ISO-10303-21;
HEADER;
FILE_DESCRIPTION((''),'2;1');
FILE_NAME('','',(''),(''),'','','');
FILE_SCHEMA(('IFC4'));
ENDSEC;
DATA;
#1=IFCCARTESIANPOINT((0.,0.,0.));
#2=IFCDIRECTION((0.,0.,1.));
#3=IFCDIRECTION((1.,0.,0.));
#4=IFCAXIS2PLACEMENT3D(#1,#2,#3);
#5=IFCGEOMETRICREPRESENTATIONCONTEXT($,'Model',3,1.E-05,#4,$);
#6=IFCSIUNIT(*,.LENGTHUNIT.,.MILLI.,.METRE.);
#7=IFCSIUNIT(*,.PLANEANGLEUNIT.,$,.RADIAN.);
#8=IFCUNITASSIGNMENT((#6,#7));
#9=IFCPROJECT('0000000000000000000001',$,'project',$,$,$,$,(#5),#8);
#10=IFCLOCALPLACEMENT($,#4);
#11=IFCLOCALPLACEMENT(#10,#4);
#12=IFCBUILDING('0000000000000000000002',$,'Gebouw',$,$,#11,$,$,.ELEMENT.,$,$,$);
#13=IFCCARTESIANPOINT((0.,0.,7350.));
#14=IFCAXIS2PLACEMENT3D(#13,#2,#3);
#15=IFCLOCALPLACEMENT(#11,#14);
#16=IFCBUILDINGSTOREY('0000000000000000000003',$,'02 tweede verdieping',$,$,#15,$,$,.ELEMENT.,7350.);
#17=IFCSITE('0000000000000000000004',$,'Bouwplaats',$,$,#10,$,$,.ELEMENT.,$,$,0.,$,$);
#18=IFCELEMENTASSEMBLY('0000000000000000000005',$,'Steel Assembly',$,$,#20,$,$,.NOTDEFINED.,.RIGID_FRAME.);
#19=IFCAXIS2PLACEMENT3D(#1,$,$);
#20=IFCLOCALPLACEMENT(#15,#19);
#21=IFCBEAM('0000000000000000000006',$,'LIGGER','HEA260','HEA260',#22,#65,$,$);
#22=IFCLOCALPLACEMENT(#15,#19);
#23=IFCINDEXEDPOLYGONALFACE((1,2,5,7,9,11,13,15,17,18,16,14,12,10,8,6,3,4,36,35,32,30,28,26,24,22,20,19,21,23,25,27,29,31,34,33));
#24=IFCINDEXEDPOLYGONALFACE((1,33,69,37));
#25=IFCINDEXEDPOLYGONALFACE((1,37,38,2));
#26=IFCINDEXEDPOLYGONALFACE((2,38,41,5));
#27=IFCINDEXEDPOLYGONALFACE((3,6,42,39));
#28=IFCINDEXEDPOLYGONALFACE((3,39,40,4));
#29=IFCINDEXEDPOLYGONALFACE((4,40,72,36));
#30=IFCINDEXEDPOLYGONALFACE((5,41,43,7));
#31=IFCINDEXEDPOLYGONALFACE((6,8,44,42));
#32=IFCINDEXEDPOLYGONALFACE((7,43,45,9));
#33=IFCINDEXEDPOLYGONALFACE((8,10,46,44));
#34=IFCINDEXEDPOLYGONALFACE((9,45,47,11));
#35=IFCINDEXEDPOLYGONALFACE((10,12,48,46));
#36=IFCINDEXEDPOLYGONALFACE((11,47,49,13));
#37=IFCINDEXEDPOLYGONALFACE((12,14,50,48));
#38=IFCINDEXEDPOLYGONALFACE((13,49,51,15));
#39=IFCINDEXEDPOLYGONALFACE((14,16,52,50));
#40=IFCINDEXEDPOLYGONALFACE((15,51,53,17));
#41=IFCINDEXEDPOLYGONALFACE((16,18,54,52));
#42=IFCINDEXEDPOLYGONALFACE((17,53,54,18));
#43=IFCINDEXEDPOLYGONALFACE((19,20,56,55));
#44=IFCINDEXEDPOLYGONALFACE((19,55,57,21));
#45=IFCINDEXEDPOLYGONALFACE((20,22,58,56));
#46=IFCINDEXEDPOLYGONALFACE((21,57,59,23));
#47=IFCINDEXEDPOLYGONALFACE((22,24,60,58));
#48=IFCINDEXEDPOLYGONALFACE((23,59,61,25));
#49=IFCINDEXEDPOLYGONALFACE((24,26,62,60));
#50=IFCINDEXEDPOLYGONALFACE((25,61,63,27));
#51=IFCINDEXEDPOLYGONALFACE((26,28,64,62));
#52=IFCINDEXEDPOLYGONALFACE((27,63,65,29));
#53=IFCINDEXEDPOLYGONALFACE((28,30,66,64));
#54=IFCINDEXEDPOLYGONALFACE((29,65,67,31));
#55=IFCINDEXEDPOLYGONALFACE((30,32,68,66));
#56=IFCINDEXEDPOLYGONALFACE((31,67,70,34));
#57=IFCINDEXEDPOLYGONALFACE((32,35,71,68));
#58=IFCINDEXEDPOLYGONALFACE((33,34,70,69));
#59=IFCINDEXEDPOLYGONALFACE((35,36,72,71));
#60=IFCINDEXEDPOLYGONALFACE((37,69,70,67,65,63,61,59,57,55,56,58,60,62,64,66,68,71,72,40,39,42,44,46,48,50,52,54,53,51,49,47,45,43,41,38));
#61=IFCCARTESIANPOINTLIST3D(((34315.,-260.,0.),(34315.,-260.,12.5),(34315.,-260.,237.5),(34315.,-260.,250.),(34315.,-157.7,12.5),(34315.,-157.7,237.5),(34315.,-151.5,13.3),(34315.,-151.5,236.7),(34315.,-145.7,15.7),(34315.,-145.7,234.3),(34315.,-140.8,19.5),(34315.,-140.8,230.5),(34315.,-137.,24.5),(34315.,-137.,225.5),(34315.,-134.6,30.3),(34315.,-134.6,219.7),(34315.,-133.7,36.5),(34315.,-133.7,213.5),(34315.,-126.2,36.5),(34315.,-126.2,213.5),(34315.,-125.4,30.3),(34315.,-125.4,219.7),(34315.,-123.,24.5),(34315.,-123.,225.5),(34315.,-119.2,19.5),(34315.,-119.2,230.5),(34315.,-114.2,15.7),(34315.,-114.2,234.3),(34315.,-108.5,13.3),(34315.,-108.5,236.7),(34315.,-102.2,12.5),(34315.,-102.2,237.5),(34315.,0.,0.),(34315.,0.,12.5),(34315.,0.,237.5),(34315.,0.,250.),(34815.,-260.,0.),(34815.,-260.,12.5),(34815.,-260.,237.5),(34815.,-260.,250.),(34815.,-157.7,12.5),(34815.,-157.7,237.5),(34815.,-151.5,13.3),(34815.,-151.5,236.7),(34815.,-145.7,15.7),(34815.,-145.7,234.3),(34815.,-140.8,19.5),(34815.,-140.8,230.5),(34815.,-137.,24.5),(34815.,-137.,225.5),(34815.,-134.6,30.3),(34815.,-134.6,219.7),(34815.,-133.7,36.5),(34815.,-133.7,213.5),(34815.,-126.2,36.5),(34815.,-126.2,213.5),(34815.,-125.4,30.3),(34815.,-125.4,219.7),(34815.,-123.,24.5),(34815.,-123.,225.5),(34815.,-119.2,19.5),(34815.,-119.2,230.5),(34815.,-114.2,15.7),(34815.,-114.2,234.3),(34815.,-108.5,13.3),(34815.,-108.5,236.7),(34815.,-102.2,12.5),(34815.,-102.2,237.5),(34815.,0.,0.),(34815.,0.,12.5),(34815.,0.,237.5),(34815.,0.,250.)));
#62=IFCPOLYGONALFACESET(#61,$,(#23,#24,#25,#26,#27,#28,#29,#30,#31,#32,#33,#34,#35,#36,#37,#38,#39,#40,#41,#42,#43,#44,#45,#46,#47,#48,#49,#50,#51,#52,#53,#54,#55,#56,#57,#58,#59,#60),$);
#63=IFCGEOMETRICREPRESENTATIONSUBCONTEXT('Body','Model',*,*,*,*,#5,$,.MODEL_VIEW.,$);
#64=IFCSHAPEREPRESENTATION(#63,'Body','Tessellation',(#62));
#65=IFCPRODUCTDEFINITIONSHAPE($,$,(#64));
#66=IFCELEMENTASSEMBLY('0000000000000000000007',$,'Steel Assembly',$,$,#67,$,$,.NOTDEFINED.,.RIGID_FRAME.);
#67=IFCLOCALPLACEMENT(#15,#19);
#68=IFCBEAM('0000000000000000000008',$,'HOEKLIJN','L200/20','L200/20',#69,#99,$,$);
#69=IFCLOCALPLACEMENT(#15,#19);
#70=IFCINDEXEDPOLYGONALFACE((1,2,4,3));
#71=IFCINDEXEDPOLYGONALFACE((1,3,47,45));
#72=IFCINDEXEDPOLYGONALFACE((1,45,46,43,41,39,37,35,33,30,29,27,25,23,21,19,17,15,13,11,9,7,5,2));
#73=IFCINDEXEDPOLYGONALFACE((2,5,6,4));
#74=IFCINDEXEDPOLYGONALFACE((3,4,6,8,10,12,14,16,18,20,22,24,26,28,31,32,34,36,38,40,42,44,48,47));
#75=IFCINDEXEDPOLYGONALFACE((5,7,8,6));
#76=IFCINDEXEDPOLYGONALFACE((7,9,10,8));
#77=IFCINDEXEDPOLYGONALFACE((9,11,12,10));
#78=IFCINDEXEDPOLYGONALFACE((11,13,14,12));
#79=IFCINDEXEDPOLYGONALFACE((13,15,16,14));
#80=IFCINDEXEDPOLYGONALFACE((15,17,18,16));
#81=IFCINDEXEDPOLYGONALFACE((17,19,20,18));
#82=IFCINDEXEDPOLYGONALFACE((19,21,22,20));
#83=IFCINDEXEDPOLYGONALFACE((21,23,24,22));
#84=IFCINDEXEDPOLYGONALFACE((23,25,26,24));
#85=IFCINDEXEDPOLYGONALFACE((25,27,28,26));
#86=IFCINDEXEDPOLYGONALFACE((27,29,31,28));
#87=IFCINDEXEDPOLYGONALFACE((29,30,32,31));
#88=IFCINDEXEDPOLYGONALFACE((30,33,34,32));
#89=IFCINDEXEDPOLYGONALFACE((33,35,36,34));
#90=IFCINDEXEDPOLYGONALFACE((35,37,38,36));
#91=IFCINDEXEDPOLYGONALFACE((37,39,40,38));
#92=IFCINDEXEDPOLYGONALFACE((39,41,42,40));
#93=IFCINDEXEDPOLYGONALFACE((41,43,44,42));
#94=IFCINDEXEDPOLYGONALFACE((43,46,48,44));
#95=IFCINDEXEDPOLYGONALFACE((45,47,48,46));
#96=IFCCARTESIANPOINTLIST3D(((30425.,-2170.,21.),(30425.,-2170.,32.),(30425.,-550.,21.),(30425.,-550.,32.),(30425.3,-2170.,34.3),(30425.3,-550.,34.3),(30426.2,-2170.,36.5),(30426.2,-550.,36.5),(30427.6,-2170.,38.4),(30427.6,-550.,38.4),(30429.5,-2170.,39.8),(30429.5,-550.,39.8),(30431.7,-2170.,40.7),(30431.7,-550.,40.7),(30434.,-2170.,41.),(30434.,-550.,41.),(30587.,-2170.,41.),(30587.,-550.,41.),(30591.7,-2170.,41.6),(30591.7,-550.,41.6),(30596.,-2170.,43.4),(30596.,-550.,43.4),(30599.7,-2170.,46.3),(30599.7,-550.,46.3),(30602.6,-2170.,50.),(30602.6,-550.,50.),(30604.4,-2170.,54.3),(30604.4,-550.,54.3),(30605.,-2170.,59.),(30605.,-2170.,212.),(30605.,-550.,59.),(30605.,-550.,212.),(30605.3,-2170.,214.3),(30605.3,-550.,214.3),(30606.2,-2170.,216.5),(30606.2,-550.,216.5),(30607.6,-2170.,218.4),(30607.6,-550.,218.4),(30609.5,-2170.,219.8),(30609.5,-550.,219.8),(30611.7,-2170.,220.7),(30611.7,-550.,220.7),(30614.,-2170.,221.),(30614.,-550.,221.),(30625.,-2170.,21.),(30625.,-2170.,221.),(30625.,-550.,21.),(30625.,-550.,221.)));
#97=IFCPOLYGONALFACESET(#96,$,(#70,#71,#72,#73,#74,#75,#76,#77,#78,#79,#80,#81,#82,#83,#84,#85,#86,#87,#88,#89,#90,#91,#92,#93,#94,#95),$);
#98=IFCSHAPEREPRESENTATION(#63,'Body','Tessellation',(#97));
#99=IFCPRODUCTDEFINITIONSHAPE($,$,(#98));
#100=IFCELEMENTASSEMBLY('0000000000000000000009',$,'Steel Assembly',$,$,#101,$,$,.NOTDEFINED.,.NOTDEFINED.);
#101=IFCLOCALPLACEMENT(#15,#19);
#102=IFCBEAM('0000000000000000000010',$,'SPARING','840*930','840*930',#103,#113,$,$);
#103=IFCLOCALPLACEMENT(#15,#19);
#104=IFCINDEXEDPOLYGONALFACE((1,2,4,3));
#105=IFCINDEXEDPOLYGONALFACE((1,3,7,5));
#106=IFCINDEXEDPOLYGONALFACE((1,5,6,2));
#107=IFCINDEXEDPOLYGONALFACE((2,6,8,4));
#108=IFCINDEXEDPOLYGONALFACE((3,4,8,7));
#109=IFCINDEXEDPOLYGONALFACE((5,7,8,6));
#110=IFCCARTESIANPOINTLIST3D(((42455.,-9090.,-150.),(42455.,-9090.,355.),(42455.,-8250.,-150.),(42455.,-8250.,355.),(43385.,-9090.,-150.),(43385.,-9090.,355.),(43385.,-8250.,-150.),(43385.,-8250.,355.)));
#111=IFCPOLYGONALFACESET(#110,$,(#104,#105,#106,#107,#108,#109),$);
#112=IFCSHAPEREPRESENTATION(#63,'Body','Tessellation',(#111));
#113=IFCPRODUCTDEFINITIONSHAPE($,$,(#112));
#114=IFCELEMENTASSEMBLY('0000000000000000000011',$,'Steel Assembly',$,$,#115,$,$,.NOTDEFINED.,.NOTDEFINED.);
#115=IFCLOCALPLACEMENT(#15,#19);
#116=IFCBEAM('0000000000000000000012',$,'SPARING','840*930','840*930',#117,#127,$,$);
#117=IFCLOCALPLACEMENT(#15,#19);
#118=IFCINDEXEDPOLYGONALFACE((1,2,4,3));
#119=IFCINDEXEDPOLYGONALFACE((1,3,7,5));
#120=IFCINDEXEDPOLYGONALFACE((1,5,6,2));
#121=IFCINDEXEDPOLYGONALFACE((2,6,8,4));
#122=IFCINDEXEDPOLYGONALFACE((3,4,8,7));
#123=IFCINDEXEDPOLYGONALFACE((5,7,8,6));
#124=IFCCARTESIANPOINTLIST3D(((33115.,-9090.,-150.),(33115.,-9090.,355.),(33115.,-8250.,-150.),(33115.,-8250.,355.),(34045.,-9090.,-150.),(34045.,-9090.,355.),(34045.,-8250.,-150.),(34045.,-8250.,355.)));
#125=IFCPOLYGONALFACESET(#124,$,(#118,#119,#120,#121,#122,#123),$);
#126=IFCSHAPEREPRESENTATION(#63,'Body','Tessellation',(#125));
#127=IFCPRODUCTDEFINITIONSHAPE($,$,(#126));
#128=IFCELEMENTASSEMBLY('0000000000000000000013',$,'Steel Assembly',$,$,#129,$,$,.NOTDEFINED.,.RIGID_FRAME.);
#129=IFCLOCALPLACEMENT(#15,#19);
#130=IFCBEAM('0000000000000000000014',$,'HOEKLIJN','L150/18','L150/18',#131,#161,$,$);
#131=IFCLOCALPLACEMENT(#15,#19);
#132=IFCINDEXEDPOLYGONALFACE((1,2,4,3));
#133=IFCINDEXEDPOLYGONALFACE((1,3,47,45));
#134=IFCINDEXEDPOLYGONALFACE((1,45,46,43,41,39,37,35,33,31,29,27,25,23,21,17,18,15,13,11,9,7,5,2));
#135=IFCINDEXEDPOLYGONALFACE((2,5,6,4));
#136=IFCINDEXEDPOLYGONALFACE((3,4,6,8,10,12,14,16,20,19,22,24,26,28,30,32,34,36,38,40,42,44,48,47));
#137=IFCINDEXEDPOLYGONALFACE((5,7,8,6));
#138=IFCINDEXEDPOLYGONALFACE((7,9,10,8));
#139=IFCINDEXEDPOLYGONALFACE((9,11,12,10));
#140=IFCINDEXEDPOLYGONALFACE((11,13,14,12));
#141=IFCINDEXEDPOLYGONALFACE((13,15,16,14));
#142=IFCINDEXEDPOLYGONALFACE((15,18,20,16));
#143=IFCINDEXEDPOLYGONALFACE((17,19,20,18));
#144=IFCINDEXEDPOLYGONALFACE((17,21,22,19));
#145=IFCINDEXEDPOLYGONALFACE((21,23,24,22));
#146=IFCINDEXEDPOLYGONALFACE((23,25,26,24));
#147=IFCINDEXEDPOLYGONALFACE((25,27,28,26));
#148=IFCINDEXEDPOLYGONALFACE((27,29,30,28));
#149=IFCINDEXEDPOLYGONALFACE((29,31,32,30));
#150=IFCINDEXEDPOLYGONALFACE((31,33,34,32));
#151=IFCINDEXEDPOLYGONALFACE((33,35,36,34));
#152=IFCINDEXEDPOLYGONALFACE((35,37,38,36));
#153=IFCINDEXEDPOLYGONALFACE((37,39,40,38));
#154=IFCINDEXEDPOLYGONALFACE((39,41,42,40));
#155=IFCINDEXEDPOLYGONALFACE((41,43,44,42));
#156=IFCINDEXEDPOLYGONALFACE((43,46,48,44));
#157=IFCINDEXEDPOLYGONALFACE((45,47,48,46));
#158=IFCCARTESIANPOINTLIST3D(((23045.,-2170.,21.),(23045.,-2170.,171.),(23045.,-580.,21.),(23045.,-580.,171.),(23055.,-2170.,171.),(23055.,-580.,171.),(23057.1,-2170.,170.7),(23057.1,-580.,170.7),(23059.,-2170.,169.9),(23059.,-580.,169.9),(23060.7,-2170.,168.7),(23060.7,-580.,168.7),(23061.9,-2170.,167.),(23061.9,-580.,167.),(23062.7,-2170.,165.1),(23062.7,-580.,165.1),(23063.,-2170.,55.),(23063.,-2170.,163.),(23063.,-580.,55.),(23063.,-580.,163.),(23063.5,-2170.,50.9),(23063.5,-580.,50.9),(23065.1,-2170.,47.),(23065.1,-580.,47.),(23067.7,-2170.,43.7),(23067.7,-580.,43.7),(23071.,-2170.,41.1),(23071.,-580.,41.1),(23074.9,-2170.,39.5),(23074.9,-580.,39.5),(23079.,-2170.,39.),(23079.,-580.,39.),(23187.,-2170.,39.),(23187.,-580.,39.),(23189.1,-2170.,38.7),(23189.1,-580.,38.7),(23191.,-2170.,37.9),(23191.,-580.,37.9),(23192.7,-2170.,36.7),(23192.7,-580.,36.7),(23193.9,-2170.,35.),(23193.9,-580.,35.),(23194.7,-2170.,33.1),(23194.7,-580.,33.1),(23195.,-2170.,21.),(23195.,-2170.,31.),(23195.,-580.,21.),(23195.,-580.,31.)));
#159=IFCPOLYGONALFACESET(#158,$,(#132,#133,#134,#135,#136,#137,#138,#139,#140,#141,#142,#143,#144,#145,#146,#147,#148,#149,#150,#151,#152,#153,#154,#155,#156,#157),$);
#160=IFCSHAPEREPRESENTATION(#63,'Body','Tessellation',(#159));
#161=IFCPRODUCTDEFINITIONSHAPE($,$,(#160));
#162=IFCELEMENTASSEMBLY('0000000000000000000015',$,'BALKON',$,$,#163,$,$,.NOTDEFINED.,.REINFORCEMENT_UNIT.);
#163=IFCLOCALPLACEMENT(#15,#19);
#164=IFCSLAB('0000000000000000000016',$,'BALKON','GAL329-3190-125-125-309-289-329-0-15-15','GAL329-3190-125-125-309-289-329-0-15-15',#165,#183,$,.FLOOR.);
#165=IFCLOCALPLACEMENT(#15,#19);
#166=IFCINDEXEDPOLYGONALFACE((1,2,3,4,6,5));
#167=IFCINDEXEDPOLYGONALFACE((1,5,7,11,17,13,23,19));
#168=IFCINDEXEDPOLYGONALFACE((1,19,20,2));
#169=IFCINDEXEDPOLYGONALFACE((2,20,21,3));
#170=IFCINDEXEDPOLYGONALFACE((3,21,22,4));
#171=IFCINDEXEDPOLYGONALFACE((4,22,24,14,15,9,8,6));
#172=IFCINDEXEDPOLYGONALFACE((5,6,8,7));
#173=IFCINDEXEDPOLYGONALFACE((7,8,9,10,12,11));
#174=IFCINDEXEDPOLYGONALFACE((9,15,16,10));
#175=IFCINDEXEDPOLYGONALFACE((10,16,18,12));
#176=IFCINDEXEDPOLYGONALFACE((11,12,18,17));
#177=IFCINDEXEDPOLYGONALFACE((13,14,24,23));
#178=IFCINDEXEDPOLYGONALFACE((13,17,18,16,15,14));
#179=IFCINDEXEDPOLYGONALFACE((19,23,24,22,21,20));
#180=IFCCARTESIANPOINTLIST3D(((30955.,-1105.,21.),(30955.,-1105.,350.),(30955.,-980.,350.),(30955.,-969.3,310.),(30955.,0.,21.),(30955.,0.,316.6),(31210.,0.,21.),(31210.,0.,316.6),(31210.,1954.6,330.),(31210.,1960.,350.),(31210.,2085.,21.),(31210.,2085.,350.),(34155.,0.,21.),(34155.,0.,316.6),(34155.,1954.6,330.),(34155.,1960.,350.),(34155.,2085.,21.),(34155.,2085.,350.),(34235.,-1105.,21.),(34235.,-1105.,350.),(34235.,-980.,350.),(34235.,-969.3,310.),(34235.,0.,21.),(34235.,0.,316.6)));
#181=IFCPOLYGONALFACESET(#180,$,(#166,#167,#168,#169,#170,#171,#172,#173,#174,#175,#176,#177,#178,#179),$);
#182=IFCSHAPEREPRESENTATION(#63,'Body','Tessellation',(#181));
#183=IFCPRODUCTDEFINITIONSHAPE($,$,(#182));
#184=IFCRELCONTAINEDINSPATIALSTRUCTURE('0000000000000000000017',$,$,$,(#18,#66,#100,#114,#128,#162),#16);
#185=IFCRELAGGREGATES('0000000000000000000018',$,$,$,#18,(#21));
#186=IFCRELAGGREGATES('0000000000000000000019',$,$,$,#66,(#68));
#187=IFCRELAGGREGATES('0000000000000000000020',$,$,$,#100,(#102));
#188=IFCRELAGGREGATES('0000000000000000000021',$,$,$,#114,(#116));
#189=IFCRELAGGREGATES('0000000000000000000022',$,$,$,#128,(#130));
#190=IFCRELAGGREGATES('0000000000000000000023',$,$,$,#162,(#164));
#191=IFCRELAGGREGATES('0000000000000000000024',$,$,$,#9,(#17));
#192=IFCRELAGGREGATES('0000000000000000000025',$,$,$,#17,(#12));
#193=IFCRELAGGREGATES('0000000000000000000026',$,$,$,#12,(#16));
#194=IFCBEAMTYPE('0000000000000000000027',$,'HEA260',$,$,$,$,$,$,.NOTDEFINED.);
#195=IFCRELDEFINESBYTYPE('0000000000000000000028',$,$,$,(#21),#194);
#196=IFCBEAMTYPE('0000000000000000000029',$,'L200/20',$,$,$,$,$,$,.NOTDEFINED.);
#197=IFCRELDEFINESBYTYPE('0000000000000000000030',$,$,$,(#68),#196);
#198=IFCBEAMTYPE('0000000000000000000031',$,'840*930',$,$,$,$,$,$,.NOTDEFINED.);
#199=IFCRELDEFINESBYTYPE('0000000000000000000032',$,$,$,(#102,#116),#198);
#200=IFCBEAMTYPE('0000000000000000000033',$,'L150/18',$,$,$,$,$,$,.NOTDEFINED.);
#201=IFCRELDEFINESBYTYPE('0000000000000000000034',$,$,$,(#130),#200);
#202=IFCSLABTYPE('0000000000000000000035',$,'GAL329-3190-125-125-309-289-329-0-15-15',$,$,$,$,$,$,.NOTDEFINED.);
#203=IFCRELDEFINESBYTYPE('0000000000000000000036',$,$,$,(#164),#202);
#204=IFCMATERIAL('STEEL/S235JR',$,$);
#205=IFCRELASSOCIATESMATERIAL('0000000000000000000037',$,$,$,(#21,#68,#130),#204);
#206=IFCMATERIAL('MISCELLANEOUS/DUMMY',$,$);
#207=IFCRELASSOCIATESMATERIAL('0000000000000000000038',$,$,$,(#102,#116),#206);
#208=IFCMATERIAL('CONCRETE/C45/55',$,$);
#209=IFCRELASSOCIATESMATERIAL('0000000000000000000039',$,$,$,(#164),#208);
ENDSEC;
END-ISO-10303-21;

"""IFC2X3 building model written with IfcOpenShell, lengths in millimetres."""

from ifc_helpers import new_model, si_unit, frame, origin_with_axes, origin_2d_with_axis, place, context, subcontext, project, spatial, polyline, rectangle, i_section, l_section, outline, extrude, boolean, material, type_object, element, aggregate, save


model = new_model("IFC2X3")

# Units and contexts
model_context = context("Model", 3, precision=1e-05, world=origin_with_axes())
body_context = subcontext(model_context, "Body", "Model", "MODEL_VIEW")
ifc_project = project(units=[si_unit("LENGTHUNIT", "METRE", prefix="MILLI"), si_unit("PLANEANGLEUNIT", "RADIAN")], contexts=[model_context])

# Site, building, storey
site_placement = place(None, origin_with_axes())
site = spatial("IfcSite", under=ifc_project, at=site_placement, Name="Bouwplaats", CompositionType="ELEMENT", RefElevation=0.0)
building_placement = place(site_placement, origin_with_axes())
building = spatial("IfcBuilding", under=site, at=building_placement, Name="Gebouw", CompositionType="ELEMENT")
storey_placement = place(building_placement, frame((0.0, 0.0, 7350.0), z_axis=(0.0, 0.0, 1.0), x_axis=(1.0, 0.0, 0.0)))
storey = spatial("IfcBuildingStorey", under=building, at=storey_placement, Name="02 tweede verdieping", CompositionType="ELEMENT", Elevation=7350.0)

# Shared definitions
ifc_material_1 = material(Name="STEEL/S235JR")

# Element assemblies, beams
ifc_material_2 = material(Name="MISCELLANEOUS/DUMMY")
beam_type_1 = type_object("IfcBeamType", Name="HEA260", PredefinedType="NOTDEFINED")
assembly_1_placement = place(storey_placement, origin_with_axes())
assembly_1 = element("IfcElementAssembly", 1, at=assembly_1_placement, inside=storey, Name="Steel Assembly", AssemblyPlace="NOTDEFINED", PredefinedType="RIGID_FRAME")
beam_1_placement = place(assembly_1_placement, frame((34315.0, -130.0, 125.0), z_axis=(0.0, 0.0, 1.0), x_axis=(1.0, 0.0, 0.0)))
beam_1 = element("IfcBeam", 2, at=beam_1_placement, type_object=beam_type_1, material=ifc_material_1, Name="LIGGER", Description="HEA260", ObjectType="HEA260", context=body_context, shape_type="SweptSolid", body=[
    extrude(i_section(OverallWidth=260.0, OverallDepth=250.0, WebThickness=7.5, FlangeThickness=12.5, FilletRadius=24.0, at=origin_2d_with_axis()), frame((500.0, 0.0, 0.0), z_axis=(-1.0, 0.0, 0.0), x_axis=(0.0, -1.0, 0.0)), (0.0, 0.0, 1.0), 500.0),
])
aggregate(assembly_1, [beam_1])
assembly_2_placement = place(storey_placement, origin_with_axes())
assembly_2 = element("IfcElementAssembly", 3, at=assembly_2_placement, inside=storey, Name="Steel Assembly", AssemblyPlace="NOTDEFINED", PredefinedType="RIGID_FRAME")
beam_type_2 = type_object("IfcBeamType", Name="L200/20", PredefinedType="NOTDEFINED")
beam_2_placement = place(assembly_2_placement, frame((30525.0, -2170.0, 121.0), z_axis=(-1.0, 0.0, 0.0), x_axis=(0.0, 1.0, 0.0)))
beam_2 = element("IfcBeam", 4, at=beam_2_placement, type_object=beam_type_2, material=ifc_material_1, Name="HOEKLIJN", Description="L200/20", ObjectType="L200/20", context=body_context, shape_type="SweptSolid", body=[
    extrude(l_section(Depth=200.0, Width=200.0, Thickness=20.0, FilletRadius=18.0, EdgeRadius=9.0, at=origin_2d_with_axis()), frame((1620.0, 0.0, 0.0), z_axis=(-1.0, 0.0, 0.0), x_axis=(0.0, -1.0, 0.0)), (0.0, 0.0, 1.0), 1620.0),
])
aggregate(assembly_2, [beam_2])
assembly_3_placement = place(storey_placement, origin_with_axes())
assembly_3 = element("IfcElementAssembly", 5, at=assembly_3_placement, inside=storey, Name="Steel Assembly", AssemblyPlace="NOTDEFINED", PredefinedType="NOTDEFINED")
beam_type_3 = type_object("IfcBeamType", Name="840*930", PredefinedType="NOTDEFINED")
beam_3_placement = place(assembly_3_placement, frame((42920.0, -8670.0, 355.0), z_axis=(1.0, -0.000004, 0.0), x_axis=(0.0, 0.0, -1.0)))
beam_3 = element("IfcBeam", 6, at=beam_3_placement, type_object=beam_type_3, material=ifc_material_2, Name="SPARING", Description="840*930", ObjectType="840*930", context=body_context, shape_type="SweptSolid", body=[
    extrude(rectangle(XDim=840.0, YDim=930.0, at=origin_2d_with_axis()), frame((505.0, 0.0, 0.0), z_axis=(-1.0, 0.0, 0.0), x_axis=(0.0, -1.0, 0.0)), (0.0, 0.0, 1.0), 505.0),
])
aggregate(assembly_3, [beam_3])
assembly_4_placement = place(storey_placement, origin_with_axes())
assembly_4 = element("IfcElementAssembly", 7, at=assembly_4_placement, inside=storey, Name="Steel Assembly", AssemblyPlace="NOTDEFINED", PredefinedType="NOTDEFINED")
beam_4_placement = place(assembly_4_placement, frame((33580.0, -8670.0, 355.0), z_axis=(1.0, -0.000004, 0.0), x_axis=(0.0, 0.0, -1.0)))
beam_4 = element("IfcBeam", 8, at=beam_4_placement, type_object=beam_type_3, material=ifc_material_2, Name="SPARING", Description="840*930", ObjectType="840*930", context=body_context, shape_type="SweptSolid", body=[
    extrude(rectangle(XDim=840.0, YDim=930.0, at=origin_2d_with_axis()), frame((505.0, 0.0, 0.0), z_axis=(-1.0, 0.0, 0.0), x_axis=(0.0, -1.0, 0.0)), (0.0, 0.0, 1.0), 505.0),
])
aggregate(assembly_4, [beam_4])
assembly_5_placement = place(storey_placement, origin_with_axes())
assembly_5 = element("IfcElementAssembly", 9, at=assembly_5_placement, inside=storey, Name="Steel Assembly", AssemblyPlace="NOTDEFINED", PredefinedType="RIGID_FRAME")
beam_type_4 = type_object("IfcBeamType", Name="L150/18", PredefinedType="NOTDEFINED")
beam_5_placement = place(assembly_5_placement, frame((23120.0, -2170.0, 96.0), z_axis=(0.0, 0.0, 1.0), x_axis=(0.0, 1.0, 0.0)))
beam_5 = element("IfcBeam", 10, at=beam_5_placement, type_object=beam_type_4, material=ifc_material_1, Name="HOEKLIJN", Description="L150/18", ObjectType="L150/18", context=body_context, shape_type="SweptSolid", body=[
    extrude(l_section(Depth=150.0, Width=150.0, Thickness=18.0, FilletRadius=16.0, EdgeRadius=8.0, at=origin_2d_with_axis()), frame((1590.0, 0.0, 0.0), z_axis=(-1.0, 0.0, 0.0), x_axis=(0.0, -1.0, 0.0)), (0.0, 0.0, 1.0), 1590.0),
])
aggregate(assembly_5, [beam_5])

# Element assembly, slab
assembly_6_placement = place(storey_placement, origin_with_axes())
assembly_6 = element("IfcElementAssembly", 11, at=assembly_6_placement, inside=storey, Name="BALKON", AssemblyPlace="NOTDEFINED", PredefinedType="REINFORCEMENT_UNIT")
ifc_material_3 = material(Name="CONCRETE/C45/55")
slab_type_1 = type_object("IfcSlabType", Name="GAL329-3190-125-125-309-289-329-0-15-15", PredefinedType="NOTDEFINED")
slab_1_placement = place(assembly_6_placement, frame((30955.0, 490.0, 185.5), z_axis=(0.0, 0.0, 1.0), x_axis=(1.0, 0.0, 0.0)))
slab_1 = element("IfcSlab", 12, at=slab_1_placement, type_object=slab_type_1, material=ifc_material_3, Name="BALKON", Description="GAL329-3190-125-125-309-289-329-0-15-15", ObjectType="GAL329-3190-125-125-309-289-329-0-15-15", PredefinedType="FLOOR", context=body_context, shape_type="CSG", body=[
    boolean("DIFFERENCE", boolean("DIFFERENCE", extrude(outline(polyline([(1595.0, -164.5), (-1595.0, -164.5), (-1595.0, 164.5), (-1470.0, 164.5), (-1464.6, 144.5), (1459.3, 124.5), (1470.0, 164.5), (1595.0, 164.5), (1595.0, -164.5)])), frame((3280.0, 0.0, 0.0), z_axis=(-1.0, 0.0, 0.0), x_axis=(0.0, -1.0, 0.0)), (0.0, 0.0, 1.0), 3280.0), extrude(rectangle(XDim=350.0, YDim=80.0, at=origin_2d_with_axis()), frame((3240.0, 1595.0, -10.5), z_axis=(0.0, -1.0, 0.0), x_axis=(0.0, 0.0, -1.0)), (0.0, 0.0, 1.0), 2085.0)), extrude(rectangle(XDim=350.0, YDim=255.0, at=origin_2d_with_axis()), frame((127.5, -490.0, -10.5), z_axis=(0.0, 1.0, 0.0), x_axis=(0.0, 0.0, -1.0)), (0.0, 0.0, 1.0), 2085.0)),
])
aggregate(assembly_6, [slab_1])

save(model, "model.ifc")
